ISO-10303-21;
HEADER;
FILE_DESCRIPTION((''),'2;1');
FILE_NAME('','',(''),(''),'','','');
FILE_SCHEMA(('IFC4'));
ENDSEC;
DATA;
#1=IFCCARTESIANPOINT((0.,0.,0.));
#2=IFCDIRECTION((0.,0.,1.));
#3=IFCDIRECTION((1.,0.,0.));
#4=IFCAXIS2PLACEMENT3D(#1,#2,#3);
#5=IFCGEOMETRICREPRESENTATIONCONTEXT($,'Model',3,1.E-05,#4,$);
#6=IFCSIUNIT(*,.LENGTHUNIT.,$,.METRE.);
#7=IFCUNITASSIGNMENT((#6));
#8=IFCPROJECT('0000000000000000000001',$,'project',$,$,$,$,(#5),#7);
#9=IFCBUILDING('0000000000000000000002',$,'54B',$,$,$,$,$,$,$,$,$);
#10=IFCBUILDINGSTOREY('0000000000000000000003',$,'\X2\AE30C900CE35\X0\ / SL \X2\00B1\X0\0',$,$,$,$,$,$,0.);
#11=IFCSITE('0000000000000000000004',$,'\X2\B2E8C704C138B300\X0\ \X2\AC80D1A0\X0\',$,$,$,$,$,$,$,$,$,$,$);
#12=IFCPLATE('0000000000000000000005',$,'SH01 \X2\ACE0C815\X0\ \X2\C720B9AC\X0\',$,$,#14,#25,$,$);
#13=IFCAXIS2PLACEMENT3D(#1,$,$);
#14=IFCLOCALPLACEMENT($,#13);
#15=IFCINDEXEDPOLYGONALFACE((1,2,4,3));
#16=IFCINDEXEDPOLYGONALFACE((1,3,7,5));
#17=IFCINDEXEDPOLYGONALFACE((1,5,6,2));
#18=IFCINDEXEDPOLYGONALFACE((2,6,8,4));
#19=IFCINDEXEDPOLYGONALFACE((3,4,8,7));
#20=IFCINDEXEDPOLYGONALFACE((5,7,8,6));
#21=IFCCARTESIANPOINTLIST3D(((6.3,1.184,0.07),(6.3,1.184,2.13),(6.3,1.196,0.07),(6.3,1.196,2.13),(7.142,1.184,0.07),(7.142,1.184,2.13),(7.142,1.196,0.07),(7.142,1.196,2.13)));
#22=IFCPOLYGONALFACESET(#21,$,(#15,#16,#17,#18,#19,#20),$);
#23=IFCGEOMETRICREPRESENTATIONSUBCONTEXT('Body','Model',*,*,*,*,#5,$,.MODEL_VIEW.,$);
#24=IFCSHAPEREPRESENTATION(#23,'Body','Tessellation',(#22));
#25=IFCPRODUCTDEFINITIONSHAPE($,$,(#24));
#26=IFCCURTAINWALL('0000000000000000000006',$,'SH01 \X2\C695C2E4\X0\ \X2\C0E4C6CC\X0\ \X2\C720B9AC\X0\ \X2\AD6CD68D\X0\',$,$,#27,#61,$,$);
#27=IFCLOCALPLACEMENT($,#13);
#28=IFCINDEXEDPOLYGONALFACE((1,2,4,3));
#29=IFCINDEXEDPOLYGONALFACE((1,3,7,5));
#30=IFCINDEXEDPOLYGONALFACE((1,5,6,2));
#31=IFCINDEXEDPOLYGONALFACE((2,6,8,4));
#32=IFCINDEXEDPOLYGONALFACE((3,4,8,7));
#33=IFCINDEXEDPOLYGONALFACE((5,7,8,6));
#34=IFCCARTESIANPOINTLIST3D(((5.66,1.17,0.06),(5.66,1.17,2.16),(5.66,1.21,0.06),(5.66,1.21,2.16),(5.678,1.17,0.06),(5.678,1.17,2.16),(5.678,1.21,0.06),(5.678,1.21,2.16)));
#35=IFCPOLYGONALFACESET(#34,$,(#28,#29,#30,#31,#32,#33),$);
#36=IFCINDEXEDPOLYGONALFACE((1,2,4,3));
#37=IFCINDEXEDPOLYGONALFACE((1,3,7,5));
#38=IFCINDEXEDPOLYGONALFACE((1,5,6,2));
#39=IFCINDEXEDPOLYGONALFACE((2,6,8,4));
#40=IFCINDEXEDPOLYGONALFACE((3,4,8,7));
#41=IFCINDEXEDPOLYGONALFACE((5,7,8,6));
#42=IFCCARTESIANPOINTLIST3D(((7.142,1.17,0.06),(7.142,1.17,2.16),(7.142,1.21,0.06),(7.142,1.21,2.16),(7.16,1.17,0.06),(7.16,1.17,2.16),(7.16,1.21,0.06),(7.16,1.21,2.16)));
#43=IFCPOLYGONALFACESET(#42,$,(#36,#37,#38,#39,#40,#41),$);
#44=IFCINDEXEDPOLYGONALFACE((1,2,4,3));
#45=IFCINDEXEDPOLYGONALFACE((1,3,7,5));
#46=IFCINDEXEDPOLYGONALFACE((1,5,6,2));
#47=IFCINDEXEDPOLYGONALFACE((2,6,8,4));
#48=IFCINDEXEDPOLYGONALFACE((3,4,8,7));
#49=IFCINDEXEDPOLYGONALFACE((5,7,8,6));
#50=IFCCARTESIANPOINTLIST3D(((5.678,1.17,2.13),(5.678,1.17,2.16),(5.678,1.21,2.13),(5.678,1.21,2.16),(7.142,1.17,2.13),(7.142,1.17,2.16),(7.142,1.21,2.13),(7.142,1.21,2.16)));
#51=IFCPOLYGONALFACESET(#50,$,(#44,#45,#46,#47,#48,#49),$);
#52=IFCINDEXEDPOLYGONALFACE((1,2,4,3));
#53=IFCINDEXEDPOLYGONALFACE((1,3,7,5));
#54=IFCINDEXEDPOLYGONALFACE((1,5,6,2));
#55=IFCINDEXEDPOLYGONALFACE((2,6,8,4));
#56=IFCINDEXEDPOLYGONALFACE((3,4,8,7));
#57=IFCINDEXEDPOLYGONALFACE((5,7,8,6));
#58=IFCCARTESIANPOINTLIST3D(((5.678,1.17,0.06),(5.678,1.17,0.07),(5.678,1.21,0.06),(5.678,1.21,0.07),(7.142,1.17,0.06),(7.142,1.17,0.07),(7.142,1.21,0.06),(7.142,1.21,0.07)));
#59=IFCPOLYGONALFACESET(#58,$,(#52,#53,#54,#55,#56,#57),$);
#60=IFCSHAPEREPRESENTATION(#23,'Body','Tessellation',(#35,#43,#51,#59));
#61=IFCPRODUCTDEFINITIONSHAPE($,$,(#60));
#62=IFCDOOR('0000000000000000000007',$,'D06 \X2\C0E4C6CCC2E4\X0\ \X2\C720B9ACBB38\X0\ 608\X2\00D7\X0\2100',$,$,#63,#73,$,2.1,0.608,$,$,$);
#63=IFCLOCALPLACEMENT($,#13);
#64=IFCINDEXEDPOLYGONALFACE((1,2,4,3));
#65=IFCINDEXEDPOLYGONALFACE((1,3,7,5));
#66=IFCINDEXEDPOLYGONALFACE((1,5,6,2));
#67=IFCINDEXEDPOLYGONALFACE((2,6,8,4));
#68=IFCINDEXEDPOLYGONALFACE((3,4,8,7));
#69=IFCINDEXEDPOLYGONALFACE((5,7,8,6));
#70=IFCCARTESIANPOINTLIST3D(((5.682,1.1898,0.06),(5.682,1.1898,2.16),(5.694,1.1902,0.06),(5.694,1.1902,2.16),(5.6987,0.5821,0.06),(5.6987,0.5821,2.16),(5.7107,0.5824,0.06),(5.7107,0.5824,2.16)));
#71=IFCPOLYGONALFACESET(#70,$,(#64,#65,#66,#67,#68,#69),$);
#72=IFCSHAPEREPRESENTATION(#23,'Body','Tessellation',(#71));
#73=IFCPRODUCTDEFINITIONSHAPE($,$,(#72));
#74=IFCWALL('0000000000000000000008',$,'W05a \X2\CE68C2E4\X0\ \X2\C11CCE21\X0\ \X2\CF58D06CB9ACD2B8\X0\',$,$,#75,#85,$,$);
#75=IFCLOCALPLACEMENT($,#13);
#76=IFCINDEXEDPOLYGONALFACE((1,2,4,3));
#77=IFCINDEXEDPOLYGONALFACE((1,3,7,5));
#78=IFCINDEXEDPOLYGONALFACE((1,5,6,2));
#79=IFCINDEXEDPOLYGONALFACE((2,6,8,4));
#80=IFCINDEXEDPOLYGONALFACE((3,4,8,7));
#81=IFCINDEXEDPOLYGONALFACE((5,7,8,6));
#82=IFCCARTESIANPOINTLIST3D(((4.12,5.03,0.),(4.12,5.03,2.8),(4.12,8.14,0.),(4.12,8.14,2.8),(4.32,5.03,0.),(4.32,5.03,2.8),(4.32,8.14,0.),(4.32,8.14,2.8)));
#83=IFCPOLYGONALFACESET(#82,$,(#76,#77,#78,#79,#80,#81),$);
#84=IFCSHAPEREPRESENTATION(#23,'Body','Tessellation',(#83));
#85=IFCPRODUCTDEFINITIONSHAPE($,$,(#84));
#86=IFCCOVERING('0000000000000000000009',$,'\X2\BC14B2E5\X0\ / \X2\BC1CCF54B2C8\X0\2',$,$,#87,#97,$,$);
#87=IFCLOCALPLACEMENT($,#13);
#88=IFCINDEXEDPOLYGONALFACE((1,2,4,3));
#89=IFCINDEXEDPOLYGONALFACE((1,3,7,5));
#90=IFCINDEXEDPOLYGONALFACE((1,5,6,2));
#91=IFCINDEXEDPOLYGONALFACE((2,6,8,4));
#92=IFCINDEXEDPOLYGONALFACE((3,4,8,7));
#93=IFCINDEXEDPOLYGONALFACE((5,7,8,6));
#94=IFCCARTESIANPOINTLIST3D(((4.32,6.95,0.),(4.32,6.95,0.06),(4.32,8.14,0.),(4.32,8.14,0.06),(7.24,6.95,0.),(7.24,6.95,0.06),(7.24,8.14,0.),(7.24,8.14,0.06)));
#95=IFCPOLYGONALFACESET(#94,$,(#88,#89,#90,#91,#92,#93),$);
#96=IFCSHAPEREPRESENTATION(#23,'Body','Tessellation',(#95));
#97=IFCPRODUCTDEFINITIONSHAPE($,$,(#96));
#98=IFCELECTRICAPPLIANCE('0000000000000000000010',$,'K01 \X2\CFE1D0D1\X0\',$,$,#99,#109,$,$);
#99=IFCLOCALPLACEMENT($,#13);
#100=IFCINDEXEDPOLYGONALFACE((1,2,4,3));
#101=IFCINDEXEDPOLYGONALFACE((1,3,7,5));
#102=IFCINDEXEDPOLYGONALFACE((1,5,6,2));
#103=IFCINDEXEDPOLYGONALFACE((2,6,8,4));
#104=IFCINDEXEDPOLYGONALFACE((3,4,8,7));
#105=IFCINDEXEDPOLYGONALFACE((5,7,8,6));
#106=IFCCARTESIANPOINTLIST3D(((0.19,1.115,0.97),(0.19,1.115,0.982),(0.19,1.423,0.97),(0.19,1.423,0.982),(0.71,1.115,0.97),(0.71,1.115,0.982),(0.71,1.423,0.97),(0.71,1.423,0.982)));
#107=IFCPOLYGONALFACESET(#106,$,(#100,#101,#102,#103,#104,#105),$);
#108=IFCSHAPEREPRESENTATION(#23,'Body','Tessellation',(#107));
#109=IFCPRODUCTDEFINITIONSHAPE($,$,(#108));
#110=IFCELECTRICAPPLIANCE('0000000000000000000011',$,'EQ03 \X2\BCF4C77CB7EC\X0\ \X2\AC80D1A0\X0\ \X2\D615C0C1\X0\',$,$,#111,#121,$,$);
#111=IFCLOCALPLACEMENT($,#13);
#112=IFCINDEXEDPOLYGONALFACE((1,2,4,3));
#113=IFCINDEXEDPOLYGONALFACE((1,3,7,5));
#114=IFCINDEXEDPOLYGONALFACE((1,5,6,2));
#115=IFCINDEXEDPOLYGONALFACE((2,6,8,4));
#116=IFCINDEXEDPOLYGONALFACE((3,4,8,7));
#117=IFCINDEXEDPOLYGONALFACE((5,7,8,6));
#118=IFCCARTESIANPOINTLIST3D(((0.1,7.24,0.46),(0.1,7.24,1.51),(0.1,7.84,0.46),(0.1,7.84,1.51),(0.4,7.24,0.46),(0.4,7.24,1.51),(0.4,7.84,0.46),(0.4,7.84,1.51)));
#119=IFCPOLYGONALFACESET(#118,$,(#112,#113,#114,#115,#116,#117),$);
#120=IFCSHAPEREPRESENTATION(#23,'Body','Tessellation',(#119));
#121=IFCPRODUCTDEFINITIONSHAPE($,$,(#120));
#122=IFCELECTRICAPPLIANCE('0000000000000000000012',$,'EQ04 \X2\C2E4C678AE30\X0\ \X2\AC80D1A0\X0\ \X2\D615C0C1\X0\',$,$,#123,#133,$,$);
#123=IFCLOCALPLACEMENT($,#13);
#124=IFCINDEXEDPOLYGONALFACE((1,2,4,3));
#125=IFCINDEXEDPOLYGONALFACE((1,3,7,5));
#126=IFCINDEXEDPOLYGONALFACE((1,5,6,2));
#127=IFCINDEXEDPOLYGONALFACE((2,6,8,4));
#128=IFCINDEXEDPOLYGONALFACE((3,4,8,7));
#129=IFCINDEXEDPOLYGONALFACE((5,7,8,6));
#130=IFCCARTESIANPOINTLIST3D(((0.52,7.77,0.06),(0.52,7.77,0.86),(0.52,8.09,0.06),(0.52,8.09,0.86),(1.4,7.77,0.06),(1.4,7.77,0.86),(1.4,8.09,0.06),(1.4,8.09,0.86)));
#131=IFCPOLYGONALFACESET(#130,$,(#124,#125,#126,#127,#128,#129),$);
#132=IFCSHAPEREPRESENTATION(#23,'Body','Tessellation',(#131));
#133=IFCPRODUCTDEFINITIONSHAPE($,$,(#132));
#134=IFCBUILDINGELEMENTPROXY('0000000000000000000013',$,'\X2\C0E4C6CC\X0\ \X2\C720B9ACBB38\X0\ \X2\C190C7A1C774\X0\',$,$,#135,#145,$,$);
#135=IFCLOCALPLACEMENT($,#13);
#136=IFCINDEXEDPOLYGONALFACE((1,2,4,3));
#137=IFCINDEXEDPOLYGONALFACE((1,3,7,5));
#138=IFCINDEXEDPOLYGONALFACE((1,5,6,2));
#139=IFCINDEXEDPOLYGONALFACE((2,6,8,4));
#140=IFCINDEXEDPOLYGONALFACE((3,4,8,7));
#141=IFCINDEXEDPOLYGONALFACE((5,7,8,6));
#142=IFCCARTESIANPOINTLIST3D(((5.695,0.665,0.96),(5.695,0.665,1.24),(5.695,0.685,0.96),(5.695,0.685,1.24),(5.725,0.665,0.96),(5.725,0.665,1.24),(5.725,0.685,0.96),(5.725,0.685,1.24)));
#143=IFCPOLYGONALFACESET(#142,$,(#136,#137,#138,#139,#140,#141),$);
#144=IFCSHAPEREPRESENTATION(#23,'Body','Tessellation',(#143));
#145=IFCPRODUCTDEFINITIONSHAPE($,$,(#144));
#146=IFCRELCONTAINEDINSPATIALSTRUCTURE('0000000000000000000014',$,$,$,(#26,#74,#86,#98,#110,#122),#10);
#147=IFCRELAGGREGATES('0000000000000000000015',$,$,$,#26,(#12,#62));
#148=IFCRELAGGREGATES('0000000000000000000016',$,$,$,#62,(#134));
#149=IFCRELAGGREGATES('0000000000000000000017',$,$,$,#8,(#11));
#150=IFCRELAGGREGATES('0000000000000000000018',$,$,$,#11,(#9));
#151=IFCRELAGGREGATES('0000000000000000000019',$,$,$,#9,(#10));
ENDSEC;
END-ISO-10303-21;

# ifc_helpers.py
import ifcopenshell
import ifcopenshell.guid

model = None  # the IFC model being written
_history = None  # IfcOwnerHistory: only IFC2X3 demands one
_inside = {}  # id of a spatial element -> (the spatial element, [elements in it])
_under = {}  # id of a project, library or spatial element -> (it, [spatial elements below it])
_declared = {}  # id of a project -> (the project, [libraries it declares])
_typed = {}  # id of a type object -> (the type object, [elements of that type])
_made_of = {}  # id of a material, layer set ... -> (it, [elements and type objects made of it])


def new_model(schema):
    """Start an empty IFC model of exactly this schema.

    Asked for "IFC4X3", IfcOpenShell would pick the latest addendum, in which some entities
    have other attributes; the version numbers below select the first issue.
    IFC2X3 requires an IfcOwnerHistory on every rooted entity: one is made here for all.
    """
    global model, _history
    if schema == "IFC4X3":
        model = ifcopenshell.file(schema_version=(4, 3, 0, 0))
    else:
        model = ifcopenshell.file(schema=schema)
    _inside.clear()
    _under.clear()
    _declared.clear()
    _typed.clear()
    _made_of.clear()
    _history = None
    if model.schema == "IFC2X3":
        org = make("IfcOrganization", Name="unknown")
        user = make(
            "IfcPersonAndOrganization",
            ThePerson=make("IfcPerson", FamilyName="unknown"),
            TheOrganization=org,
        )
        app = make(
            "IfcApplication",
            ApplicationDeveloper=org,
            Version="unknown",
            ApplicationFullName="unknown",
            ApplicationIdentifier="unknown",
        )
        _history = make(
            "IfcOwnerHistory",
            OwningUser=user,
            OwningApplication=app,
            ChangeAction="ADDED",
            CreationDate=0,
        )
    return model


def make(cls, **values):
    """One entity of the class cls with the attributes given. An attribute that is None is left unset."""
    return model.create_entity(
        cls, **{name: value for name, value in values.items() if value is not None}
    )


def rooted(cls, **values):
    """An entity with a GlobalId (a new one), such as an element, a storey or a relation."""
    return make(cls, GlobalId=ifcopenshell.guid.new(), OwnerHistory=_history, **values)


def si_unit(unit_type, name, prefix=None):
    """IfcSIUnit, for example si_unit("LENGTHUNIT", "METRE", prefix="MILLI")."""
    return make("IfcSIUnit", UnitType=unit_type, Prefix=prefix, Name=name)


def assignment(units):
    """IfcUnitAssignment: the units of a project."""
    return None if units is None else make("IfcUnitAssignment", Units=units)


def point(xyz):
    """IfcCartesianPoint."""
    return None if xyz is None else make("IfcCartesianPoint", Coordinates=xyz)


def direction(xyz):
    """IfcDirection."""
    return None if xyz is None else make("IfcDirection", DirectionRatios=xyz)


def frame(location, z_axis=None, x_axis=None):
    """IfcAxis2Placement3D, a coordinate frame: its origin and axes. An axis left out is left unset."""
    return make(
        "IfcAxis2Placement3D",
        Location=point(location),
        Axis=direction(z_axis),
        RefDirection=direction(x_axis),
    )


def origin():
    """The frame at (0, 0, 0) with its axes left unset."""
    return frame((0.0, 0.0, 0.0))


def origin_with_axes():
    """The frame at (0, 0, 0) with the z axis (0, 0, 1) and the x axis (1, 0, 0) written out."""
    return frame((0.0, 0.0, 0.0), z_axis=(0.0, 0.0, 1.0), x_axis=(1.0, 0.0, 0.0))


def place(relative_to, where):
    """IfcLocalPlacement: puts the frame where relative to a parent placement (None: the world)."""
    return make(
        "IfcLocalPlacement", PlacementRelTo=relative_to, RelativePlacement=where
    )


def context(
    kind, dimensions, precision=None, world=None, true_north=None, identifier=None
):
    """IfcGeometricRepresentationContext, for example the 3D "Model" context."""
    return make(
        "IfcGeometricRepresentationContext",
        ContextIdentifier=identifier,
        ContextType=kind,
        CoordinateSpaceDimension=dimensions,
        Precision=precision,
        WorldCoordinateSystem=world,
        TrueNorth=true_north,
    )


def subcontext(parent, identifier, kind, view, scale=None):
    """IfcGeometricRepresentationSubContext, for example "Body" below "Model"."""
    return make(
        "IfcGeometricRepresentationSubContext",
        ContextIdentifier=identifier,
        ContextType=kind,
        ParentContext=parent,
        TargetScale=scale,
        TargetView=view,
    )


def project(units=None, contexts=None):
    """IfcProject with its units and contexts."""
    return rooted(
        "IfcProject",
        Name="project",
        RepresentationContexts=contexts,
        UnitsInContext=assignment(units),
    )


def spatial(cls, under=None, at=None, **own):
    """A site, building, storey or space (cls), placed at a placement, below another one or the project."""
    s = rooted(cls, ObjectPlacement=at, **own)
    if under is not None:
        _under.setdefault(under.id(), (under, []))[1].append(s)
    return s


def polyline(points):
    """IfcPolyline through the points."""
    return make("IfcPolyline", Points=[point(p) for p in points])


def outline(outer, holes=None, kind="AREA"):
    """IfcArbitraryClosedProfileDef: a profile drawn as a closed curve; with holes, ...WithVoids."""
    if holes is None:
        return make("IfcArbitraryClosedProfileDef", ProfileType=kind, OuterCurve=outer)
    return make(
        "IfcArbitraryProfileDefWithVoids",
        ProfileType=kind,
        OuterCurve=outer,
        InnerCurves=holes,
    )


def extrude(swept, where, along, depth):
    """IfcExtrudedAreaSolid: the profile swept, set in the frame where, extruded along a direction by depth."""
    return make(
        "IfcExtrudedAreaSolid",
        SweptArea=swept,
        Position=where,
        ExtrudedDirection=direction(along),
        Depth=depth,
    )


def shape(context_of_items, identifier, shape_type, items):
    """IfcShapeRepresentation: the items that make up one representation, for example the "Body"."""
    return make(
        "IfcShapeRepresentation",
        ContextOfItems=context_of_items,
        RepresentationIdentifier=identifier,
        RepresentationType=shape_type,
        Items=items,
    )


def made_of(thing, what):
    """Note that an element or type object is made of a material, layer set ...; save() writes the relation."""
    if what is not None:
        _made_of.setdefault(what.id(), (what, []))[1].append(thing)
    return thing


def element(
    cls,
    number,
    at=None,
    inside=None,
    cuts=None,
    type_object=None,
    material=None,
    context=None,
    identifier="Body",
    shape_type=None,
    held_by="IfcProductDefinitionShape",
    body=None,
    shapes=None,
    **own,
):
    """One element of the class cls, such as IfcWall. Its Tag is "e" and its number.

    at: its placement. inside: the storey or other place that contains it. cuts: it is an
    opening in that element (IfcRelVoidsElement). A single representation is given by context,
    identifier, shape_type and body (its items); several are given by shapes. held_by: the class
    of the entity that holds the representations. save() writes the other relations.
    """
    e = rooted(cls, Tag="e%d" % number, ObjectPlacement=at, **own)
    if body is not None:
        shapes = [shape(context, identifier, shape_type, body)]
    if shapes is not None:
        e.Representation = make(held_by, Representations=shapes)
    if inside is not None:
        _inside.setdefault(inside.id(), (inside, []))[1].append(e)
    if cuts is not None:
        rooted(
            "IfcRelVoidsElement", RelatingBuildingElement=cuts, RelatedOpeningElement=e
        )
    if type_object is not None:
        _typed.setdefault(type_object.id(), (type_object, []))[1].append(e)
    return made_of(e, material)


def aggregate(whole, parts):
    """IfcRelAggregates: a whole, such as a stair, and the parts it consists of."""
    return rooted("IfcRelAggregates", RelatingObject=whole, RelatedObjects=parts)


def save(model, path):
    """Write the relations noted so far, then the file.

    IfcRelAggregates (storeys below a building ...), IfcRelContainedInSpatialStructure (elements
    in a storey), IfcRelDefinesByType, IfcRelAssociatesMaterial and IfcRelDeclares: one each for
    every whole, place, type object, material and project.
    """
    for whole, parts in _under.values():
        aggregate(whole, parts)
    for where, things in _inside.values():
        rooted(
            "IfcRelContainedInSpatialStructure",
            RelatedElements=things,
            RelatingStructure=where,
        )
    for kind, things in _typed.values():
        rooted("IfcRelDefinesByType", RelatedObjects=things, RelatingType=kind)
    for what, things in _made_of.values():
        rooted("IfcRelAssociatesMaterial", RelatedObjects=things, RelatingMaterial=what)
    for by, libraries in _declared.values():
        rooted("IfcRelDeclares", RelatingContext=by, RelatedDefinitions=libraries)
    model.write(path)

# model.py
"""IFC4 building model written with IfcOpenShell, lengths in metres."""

from ifc_helpers import new_model, si_unit, frame, origin, origin_with_axes, place, context, subcontext, project, spatial, polyline, outline, extrude, element, aggregate, save


model = new_model("IFC4")

# Units and contexts
model_context = context("Model", 3, precision=1e-05, world=origin_with_axes())
body_context = subcontext(model_context, "Body", "Model", "MODEL_VIEW")
ifc_project = project(units=[si_unit("LENGTHUNIT", "METRE")], contexts=[model_context])

# Plate
curtain_wall_placement = place(None, origin_with_axes())
plate_placement = place(curtain_wall_placement, origin_with_axes())
plate = element("IfcPlate", 1, at=plate_placement, Name="SH01 고정 유리", context=body_context, shape_type="SweptSolid", body=[
    extrude(outline(polyline([(7.142, 1.184), (7.142, 1.196), (6.3, 1.196), (6.3, 1.184), (7.142, 1.184)])), frame((0.0, 0.0, 0.07)), (0.0, 0.0, 1.0), 2.06),
])

# Site, building, storey
site = spatial("IfcSite", under=ifc_project, Name="단위세대 검토")
building = spatial("IfcBuilding", under=site, Name="54B")
storey = spatial("IfcBuildingStorey", under=building, Name="기준층 / SL ±0", Elevation=0.0)

# Curtain wall, door
curtain_wall = element("IfcCurtainWall", 2, at=curtain_wall_placement, inside=storey, Name="SH01 욕실 샤워 유리 구획", context=body_context, shape_type="SweptSolid", body=[
    extrude(outline(polyline([(5.678, 1.17), (5.678, 1.21), (5.66, 1.21), (5.66, 1.17), (5.678, 1.17)])), frame((0.0, 0.0, 0.06)), (0.0, 0.0, 1.0), 2.1),
    extrude(outline(polyline([(7.16, 1.17), (7.16, 1.21), (7.142, 1.21), (7.142, 1.17), (7.16, 1.17)])), frame((0.0, 0.0, 0.06)), (0.0, 0.0, 1.0), 2.1),
    extrude(outline(polyline([(7.142, 1.17), (7.142, 1.21), (5.678, 1.21), (5.678, 1.17), (7.142, 1.17)])), frame((0.0, 0.0, 2.13)), (0.0, 0.0, 1.0), 0.03),
    extrude(outline(polyline([(7.142, 1.17), (7.142, 1.21), (5.678, 1.21), (5.678, 1.17), (7.142, 1.17)])), frame((0.0, 0.0, 0.06)), (0.0, 0.0, 1.0), 0.01),
])
door_placement = place(curtain_wall_placement, origin_with_axes())
door = element("IfcDoor", 3, at=door_placement, Name="D06 샤워실 유리문 608×2100", OverallHeight=2.1, OverallWidth=0.608, context=body_context, shape_type="SweptSolid", body=[
    extrude(outline(polyline([(5.694, 1.1902), (5.7107, 0.5824), (5.6987, 0.5821), (5.682, 1.1898), (5.694, 1.1902)])), frame((0.0, 0.0, 0.06)), (0.0, 0.0, 1.0), 2.1),
])
aggregate(curtain_wall, [plate, door])

# Wall
wall_placement = place(None, origin_with_axes())
element("IfcWall", 4, at=wall_placement, inside=storey, Name="W05a 침실 서측 콘크리트", context=body_context, shape_type="SweptSolid", body=[
    extrude(outline(polyline([(4.12, 5.03), (4.32, 5.03), (4.32, 8.14), (4.12, 8.14), (4.12, 5.03)])), origin(), (0.0, 0.0, 1.0), 2.8),
])

# Covering
covering_placement = place(None, origin_with_axes())
element("IfcCovering", 5, at=covering_placement, inside=storey, Name="바닥 / 발코니2", context=body_context, shape_type="SweptSolid", body=[
    extrude(outline(polyline([(7.24, 6.95), (7.24, 8.14), (4.32, 8.14), (4.32, 6.95), (7.24, 6.95)])), origin(), (0.0, 0.0, 1.0), 0.06),
])

# Electric appliance
electric_appliance_1_placement = place(None, origin_with_axes())
element("IfcElectricAppliance", 6, at=electric_appliance_1_placement, inside=storey, Name="K01 쿡탑", context=body_context, shape_type="SweptSolid", body=[
    extrude(outline(polyline([(0.19, 1.115), (0.19, 1.423), (0.71, 1.423), (0.71, 1.115), (0.19, 1.115)])), frame((0.0, 0.0, 0.97)), (0.0, 0.0, 1.0), 0.012),
])

# Electric appliances
electric_appliance_2_placement = place(None, origin_with_axes())
element("IfcElectricAppliance", 7, at=electric_appliance_2_placement, inside=storey, Name="EQ03 보일러 검토 형상", context=body_context, shape_type="SweptSolid", body=[
    extrude(outline(polyline([(0.4, 7.84), (0.1, 7.84), (0.1, 7.24), (0.4, 7.24), (0.4, 7.84)])), frame((0.0, 0.0, 0.46)), (0.0, 0.0, 1.0), 1.05),
])
electric_appliance_3_placement = place(None, origin_with_axes())
element("IfcElectricAppliance", 8, at=electric_appliance_3_placement, inside=storey, Name="EQ04 실외기 검토 형상", context=body_context, shape_type="SweptSolid", body=[
    extrude(outline(polyline([(0.52, 7.77), (1.4, 7.77), (1.4, 8.09), (0.52, 8.09), (0.52, 7.77)])), frame((0.0, 0.0, 0.06)), (0.0, 0.0, 1.0), 0.8),
])

# Building element proxy
proxy_1_placement = place(door_placement, origin_with_axes())
proxy_1 = element("IfcBuildingElementProxy", 9, at=proxy_1_placement, Name="샤워 유리문 손잡이", context=body_context, shape_type="SweptSolid", body=[
    extrude(outline(polyline([(5.725, 0.665), (5.725, 0.685), (5.695, 0.685), (5.695, 0.665), (5.725, 0.665)])), frame((0.0, 0.0, 0.96)), (0.0, 0.0, 1.0), 0.28),
])
aggregate(door, [proxy_1])

save(model, "model.ifc")
